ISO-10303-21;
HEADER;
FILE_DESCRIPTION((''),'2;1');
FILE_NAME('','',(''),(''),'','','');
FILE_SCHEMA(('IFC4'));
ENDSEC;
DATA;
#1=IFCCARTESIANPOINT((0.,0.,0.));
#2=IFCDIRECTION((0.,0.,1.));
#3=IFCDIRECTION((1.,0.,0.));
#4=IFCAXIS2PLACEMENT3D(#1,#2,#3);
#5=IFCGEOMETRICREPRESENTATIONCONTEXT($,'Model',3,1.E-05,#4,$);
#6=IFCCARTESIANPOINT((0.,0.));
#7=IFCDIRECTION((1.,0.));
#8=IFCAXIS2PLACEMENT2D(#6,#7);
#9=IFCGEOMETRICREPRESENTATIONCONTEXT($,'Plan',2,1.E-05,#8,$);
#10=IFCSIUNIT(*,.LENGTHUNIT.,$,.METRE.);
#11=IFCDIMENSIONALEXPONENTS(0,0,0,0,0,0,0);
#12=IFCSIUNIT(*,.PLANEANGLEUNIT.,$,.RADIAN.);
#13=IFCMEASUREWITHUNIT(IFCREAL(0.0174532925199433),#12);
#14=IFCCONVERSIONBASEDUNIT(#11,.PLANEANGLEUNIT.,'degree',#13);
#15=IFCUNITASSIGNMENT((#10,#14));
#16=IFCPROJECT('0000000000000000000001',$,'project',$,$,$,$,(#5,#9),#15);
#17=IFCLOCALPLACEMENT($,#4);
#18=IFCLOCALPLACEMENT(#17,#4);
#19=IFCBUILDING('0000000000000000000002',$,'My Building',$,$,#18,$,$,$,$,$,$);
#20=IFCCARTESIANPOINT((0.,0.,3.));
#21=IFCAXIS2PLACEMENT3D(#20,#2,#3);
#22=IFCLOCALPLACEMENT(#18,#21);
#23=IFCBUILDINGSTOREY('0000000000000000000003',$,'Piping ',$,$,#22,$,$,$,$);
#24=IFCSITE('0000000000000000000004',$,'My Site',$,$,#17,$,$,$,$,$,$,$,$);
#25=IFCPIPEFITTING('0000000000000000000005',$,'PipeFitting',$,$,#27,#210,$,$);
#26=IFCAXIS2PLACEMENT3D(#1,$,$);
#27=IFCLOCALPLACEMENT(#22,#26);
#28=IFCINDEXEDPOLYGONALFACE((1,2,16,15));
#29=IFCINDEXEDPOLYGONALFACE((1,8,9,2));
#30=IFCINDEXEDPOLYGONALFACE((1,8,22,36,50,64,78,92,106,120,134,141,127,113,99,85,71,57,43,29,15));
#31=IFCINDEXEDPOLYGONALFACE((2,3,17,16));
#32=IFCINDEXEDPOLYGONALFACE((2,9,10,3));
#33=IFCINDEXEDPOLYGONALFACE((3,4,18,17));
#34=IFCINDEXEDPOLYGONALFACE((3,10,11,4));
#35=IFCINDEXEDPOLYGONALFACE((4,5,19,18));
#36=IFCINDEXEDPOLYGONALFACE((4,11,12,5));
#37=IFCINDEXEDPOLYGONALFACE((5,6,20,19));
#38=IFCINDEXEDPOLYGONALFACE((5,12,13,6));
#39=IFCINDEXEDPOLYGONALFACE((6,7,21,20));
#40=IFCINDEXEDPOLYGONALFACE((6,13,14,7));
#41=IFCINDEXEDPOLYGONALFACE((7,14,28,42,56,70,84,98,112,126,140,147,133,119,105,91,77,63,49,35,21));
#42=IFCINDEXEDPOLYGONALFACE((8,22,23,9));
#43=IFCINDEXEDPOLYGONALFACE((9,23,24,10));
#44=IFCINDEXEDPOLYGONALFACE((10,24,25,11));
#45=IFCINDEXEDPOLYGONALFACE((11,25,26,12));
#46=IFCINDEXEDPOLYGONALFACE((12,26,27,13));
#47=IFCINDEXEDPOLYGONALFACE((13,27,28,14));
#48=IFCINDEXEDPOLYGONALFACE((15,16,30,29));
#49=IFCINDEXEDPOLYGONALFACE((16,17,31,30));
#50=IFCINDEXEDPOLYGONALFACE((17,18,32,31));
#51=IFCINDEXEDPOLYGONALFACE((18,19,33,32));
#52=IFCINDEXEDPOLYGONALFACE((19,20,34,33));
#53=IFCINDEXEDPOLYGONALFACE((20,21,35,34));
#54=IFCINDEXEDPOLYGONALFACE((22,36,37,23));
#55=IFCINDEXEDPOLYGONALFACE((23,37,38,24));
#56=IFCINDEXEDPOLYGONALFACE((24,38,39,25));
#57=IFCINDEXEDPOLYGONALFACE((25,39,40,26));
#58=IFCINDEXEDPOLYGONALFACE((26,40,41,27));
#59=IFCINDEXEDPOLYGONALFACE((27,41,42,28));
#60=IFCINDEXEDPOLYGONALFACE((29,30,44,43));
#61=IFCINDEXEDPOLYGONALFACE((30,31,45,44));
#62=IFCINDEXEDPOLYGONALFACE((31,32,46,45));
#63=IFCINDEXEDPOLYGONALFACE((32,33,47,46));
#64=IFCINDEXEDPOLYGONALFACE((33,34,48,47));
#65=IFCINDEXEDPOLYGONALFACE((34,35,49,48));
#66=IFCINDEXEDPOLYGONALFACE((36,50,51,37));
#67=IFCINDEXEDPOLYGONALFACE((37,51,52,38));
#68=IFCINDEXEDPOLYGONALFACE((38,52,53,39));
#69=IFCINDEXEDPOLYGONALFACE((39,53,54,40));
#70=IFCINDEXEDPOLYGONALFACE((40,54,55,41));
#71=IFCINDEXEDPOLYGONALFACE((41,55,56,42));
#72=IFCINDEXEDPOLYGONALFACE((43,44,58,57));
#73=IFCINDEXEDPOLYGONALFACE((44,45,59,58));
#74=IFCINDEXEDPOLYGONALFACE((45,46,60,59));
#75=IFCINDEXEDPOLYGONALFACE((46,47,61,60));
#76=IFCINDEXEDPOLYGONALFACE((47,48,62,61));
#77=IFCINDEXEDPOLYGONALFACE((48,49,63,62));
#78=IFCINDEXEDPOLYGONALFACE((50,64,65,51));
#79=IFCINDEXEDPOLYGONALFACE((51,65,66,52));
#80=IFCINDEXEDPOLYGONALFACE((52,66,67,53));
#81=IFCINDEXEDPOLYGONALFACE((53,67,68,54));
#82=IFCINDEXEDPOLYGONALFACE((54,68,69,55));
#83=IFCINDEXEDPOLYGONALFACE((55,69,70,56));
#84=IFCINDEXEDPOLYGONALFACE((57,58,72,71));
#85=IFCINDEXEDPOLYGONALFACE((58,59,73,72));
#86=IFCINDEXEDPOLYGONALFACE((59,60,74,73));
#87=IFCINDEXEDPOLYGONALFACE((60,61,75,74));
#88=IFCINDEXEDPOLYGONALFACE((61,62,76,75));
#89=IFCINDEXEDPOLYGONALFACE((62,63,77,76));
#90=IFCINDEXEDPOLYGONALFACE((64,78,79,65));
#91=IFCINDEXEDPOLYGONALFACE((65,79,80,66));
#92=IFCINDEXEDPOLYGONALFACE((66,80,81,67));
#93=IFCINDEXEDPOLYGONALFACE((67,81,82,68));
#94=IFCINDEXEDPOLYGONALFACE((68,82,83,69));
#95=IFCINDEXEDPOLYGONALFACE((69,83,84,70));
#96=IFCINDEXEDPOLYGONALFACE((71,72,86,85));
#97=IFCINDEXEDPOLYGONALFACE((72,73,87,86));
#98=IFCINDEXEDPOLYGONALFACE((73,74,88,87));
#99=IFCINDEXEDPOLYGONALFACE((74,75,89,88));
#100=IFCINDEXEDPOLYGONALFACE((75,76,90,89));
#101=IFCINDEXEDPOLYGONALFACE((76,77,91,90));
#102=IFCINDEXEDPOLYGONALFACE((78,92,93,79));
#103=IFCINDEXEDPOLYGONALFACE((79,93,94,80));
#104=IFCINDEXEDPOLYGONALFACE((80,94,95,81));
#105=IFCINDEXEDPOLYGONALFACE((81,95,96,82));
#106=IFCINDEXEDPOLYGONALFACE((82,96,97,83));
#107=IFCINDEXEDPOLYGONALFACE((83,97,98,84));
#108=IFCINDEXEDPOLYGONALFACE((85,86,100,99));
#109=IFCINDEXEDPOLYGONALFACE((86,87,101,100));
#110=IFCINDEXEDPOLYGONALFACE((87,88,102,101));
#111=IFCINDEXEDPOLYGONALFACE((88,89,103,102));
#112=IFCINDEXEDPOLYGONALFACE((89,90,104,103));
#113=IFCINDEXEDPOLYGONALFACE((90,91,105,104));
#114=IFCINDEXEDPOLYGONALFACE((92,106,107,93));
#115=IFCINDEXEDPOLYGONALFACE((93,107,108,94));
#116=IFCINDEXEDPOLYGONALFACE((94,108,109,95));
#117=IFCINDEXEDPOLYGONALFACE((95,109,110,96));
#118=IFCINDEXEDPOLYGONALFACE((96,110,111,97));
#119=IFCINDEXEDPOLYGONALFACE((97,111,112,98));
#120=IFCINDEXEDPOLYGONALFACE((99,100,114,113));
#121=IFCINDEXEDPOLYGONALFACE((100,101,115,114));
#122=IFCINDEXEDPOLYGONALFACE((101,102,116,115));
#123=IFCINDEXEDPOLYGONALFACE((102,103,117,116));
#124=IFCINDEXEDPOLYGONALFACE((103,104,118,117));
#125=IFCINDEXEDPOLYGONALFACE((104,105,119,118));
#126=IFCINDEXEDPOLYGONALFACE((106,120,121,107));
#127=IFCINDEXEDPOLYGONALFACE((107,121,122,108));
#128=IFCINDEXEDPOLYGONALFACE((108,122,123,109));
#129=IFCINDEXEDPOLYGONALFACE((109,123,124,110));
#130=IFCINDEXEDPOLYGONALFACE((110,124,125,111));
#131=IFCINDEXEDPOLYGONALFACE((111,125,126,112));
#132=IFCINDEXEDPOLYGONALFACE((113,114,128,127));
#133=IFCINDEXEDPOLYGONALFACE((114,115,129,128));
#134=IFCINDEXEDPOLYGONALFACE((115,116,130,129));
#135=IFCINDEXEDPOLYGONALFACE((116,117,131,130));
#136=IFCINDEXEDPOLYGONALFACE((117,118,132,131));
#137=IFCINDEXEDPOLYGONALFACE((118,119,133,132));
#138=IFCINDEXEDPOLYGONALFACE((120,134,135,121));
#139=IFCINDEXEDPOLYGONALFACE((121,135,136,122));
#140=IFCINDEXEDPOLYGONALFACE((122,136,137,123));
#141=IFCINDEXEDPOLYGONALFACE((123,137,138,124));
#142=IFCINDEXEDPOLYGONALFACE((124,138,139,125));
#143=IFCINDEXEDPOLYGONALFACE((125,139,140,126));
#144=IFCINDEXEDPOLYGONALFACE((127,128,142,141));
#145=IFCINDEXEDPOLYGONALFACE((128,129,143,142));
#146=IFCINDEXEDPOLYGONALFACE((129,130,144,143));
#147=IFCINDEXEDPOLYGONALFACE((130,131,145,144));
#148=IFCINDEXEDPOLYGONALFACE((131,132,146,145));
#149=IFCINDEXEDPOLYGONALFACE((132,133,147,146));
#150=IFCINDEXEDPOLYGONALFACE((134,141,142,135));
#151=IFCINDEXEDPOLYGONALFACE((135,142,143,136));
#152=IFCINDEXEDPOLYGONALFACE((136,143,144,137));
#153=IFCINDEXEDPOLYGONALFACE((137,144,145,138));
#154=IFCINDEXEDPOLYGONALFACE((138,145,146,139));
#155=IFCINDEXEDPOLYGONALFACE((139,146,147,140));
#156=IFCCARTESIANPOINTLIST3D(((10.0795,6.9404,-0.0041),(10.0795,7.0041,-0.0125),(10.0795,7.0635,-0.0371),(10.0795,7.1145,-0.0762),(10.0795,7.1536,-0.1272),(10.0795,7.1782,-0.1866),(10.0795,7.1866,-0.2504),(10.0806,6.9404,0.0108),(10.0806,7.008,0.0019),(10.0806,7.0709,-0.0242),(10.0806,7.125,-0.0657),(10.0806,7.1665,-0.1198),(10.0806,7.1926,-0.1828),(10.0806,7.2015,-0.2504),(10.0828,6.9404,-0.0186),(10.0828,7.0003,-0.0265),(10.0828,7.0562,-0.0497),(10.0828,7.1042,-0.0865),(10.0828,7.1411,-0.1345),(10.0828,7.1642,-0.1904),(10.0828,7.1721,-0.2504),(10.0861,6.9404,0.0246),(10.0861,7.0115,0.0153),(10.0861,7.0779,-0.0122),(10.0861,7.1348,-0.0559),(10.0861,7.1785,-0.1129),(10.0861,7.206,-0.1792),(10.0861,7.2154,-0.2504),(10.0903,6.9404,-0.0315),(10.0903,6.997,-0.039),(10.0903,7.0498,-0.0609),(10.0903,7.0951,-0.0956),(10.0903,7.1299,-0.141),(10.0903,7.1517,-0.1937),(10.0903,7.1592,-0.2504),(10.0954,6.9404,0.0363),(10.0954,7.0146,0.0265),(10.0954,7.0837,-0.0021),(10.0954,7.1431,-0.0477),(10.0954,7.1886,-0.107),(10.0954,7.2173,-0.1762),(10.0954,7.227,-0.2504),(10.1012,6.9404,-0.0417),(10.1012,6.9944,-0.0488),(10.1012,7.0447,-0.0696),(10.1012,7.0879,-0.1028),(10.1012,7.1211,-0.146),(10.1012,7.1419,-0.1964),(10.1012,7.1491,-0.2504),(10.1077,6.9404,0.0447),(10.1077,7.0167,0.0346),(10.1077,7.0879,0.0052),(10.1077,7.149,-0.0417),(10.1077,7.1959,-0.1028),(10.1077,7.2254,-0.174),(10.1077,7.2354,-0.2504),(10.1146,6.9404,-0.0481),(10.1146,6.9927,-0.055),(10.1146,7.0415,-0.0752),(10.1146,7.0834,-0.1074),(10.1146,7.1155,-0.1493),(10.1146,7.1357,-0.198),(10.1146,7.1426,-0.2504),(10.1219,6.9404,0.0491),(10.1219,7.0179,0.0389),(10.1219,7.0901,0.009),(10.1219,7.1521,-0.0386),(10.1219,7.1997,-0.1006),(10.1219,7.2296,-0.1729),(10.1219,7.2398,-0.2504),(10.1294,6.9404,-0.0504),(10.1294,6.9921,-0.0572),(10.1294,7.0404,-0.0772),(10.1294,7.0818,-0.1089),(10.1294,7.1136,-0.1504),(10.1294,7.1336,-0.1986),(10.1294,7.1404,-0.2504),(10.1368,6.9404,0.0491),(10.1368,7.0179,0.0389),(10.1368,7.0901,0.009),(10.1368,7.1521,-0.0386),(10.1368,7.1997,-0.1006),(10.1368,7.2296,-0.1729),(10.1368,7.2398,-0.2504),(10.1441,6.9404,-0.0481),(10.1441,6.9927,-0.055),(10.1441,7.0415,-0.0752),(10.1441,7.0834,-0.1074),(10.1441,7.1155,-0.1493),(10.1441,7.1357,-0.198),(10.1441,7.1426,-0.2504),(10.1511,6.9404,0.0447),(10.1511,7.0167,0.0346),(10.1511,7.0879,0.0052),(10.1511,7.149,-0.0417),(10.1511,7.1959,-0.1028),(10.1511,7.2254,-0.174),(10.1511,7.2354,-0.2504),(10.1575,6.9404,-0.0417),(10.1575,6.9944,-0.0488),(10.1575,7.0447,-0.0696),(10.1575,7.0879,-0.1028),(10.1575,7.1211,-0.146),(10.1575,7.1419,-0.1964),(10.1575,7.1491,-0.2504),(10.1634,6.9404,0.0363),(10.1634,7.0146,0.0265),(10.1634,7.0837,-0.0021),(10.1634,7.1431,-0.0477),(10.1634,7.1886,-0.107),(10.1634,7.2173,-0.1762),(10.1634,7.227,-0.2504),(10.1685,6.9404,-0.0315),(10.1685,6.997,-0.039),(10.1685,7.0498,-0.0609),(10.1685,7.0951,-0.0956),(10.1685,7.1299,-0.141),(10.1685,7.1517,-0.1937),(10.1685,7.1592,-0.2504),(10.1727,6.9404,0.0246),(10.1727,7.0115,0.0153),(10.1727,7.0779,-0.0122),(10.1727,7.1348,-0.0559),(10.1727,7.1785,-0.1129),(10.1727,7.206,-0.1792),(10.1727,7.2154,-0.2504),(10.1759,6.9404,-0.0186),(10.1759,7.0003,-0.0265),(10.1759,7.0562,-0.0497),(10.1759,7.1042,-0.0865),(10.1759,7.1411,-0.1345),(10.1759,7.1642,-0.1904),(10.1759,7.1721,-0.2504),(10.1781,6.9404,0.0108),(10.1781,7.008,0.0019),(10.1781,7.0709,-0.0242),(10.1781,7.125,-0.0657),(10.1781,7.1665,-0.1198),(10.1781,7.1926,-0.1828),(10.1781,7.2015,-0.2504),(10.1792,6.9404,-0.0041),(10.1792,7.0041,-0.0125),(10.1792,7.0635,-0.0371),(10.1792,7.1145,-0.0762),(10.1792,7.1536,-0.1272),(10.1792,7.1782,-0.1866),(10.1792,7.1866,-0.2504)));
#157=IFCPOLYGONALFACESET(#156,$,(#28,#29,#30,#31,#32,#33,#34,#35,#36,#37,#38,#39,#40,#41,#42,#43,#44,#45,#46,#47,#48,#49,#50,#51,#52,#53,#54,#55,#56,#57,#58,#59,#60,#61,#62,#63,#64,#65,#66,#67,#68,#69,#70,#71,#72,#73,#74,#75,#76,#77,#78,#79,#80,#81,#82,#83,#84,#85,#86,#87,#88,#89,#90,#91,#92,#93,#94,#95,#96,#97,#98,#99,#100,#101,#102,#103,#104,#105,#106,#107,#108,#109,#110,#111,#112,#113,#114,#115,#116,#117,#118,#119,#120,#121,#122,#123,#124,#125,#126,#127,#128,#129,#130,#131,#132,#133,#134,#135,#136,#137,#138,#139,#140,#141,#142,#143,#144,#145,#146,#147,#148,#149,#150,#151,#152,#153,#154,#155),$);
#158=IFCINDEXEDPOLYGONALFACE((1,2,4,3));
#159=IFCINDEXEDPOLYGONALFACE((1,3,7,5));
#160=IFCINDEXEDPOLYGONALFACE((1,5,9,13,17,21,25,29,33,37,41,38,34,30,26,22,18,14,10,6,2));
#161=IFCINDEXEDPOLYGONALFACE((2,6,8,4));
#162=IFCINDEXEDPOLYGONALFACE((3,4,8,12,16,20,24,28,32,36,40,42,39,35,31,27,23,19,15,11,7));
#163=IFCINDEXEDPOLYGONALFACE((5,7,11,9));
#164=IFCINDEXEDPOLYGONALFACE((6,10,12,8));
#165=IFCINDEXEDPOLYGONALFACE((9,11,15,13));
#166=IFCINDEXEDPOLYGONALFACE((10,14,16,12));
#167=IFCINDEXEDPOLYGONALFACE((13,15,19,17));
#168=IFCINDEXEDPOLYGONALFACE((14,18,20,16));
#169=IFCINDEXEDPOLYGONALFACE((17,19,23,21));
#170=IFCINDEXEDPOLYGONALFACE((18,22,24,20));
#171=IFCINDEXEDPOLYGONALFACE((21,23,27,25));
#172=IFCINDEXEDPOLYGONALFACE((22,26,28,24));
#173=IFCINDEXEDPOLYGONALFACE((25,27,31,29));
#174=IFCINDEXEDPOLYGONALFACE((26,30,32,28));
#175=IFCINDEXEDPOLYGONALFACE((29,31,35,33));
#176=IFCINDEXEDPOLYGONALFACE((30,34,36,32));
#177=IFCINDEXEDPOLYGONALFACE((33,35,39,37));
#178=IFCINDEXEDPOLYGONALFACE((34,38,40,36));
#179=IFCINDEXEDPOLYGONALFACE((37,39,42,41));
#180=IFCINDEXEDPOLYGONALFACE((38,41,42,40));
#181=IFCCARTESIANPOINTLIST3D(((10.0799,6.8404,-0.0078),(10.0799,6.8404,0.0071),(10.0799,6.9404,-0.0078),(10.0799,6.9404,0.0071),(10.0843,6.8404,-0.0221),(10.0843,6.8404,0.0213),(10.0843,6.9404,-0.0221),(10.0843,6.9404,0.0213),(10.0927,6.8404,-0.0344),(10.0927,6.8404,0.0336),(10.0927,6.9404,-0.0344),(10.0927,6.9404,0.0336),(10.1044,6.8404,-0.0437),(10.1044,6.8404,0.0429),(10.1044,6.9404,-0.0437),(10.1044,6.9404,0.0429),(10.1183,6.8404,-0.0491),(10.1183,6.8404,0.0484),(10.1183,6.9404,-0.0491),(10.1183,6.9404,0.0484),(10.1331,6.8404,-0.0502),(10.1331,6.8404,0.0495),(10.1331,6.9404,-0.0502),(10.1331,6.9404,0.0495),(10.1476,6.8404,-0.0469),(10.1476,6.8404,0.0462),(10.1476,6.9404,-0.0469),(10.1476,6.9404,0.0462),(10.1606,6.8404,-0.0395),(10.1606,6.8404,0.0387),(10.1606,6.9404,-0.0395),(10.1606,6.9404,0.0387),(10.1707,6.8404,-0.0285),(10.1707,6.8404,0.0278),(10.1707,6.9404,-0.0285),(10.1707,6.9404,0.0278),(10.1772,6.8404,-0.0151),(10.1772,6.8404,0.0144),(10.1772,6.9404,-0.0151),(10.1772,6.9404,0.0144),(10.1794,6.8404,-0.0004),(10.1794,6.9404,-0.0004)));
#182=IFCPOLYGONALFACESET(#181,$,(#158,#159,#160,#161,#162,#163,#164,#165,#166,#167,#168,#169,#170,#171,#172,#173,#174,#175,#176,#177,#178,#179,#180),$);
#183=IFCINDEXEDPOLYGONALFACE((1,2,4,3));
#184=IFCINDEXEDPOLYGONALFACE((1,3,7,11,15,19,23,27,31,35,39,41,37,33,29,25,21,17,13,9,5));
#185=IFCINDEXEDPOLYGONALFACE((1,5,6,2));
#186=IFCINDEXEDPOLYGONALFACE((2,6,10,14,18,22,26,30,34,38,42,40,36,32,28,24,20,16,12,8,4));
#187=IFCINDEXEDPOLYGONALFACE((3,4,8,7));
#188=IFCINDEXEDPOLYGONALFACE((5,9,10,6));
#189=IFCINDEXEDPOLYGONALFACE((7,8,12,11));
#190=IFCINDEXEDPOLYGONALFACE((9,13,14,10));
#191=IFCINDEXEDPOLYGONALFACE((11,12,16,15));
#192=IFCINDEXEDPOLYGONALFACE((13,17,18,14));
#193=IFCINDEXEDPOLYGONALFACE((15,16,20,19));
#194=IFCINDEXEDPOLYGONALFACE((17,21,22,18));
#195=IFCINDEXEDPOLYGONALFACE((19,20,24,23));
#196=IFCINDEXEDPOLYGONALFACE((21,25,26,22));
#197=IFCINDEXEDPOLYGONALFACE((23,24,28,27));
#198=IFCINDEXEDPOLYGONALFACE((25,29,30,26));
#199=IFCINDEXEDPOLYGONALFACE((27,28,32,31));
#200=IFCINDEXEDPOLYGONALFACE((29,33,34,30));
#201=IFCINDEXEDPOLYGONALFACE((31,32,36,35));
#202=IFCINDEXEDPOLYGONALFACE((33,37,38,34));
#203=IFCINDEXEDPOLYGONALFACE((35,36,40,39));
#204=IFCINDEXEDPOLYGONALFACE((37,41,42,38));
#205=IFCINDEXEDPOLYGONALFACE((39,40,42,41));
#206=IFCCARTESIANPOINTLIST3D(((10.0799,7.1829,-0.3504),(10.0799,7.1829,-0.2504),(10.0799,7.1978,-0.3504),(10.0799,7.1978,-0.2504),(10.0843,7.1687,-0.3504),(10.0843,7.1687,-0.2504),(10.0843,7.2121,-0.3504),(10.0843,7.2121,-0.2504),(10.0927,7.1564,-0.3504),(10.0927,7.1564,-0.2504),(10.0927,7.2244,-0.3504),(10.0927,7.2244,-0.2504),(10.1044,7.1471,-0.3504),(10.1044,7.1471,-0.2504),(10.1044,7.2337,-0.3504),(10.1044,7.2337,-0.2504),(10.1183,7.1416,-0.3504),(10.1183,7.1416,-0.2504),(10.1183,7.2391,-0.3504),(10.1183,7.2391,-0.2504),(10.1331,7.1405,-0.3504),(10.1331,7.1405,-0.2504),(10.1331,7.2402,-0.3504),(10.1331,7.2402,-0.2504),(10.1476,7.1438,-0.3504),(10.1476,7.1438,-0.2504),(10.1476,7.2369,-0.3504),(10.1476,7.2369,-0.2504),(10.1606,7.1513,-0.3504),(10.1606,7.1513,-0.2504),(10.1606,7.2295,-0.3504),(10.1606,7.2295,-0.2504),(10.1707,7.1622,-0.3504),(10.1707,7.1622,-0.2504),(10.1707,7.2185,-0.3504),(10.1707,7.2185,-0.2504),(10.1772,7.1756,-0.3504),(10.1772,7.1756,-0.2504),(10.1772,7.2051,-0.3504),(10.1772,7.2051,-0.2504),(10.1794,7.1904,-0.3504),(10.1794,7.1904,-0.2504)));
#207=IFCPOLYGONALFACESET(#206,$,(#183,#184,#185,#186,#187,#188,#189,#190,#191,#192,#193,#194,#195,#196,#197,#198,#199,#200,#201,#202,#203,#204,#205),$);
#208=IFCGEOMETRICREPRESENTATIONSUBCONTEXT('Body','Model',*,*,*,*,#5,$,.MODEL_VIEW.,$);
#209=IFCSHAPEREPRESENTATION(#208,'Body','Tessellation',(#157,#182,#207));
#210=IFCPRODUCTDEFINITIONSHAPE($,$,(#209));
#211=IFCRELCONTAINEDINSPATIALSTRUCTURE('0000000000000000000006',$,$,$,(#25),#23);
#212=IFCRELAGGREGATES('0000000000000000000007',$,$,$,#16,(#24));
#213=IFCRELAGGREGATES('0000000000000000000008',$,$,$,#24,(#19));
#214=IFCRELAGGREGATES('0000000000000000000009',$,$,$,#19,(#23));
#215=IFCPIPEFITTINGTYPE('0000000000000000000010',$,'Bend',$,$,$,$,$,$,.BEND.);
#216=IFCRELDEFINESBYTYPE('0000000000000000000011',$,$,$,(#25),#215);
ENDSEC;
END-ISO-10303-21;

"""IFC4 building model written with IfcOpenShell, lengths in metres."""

from ifc_helpers import new_model, entity, si_unit, converted_unit, frame, origin_with_axes, origin_2d_with_axis, place, context, subcontext, project, spatial, circle, extrude, source, transform, mapped, type_object, type_shapes, element, save


model = new_model("IFC4")

# Units and contexts
model_context = context("Model", 3, precision=1e-05, world=origin_with_axes())
plan_context = context("Plan", 2, precision=1e-05, world=origin_2d_with_axis())
body_context = subcontext(model_context, "Body", "Model", "MODEL_VIEW")
ifc_project = project(units=[si_unit("LENGTHUNIT", "METRE"), converted_unit("PLANEANGLEUNIT", "degree", entity("IfcReal", 0.0174532925199433), si_unit("PLANEANGLEUNIT", "RADIAN"), dimensions=[0, 0, 0, 0, 0, 0, 0])], contexts=[model_context, plan_context])

# Site, building, storey
site_placement = place(None, origin_with_axes())
site = spatial("IfcSite", under=ifc_project, at=site_placement, Name="My Site")
building_placement = place(site_placement, origin_with_axes())
building = spatial("IfcBuilding", under=site, at=building_placement, Name="My Building")
storey_placement = place(building_placement, frame((0.0, 0.0, 3.0), z_axis=(0.0, 0.0, 1.0), x_axis=(1.0, 0.0, 0.0)))
storey = spatial("IfcBuildingStorey", under=building, at=storey_placement, Name="Piping ")

# Pipe fitting
pipe_fitting_type = type_object("IfcPipeFittingType", Name="Bend", PredefinedType="BEND")
shared_shape = source(origin_with_axes(), body_context, "Body", "SolidModel", [
    entity("IfcSweptDiskSolid", entity("IfcIndexedPolyCurve", entity("IfcCartesianPointList3D", [[0.0, 0.0, -0.1], [0.0, -0.0732, -0.2768], [0.0, -0.25, -0.35]]), [entity("IfcArcIndex", [1, 2, 3])]), 0.05),
    extrude(circle(Radius=0.05), origin_with_axes(), (0.0, 0.0, -1.0), 0.1),
    extrude(circle(Radius=0.05), frame((0.0, -0.25, -0.35), z_axis=(0.0, -1.0, 0.0), x_axis=(1.0, 0.0, 0.0)), (0.0, 0.0, 1.0), 0.1),
])
type_shapes(pipe_fitting_type, [shared_shape])
for number, where, z_axis, x_axis, name in (
    (1, (10.1294, 6.8404, -0.0004), (0.0, -1.0, 0.0), (1.0, 0.0, 0.0), "PipeFitting"),
):
    element("IfcPipeFitting", number, at=place(storey_placement, frame(where, z_axis=z_axis, x_axis=x_axis)), inside=storey, type_object=pipe_fitting_type, Name=name, context=body_context, shape_type="MappedRepresentation", body=[
        mapped(shared_shape, transform((0.0, 0.0, 0.0), x_axis=(1.0, 0.0, 0.0), y_axis=(0.0, 1.0, 0.0), z_axis=(0.0, 0.0, 1.0), scale=1.0)),
    ])

save(model, "model.ifc")
